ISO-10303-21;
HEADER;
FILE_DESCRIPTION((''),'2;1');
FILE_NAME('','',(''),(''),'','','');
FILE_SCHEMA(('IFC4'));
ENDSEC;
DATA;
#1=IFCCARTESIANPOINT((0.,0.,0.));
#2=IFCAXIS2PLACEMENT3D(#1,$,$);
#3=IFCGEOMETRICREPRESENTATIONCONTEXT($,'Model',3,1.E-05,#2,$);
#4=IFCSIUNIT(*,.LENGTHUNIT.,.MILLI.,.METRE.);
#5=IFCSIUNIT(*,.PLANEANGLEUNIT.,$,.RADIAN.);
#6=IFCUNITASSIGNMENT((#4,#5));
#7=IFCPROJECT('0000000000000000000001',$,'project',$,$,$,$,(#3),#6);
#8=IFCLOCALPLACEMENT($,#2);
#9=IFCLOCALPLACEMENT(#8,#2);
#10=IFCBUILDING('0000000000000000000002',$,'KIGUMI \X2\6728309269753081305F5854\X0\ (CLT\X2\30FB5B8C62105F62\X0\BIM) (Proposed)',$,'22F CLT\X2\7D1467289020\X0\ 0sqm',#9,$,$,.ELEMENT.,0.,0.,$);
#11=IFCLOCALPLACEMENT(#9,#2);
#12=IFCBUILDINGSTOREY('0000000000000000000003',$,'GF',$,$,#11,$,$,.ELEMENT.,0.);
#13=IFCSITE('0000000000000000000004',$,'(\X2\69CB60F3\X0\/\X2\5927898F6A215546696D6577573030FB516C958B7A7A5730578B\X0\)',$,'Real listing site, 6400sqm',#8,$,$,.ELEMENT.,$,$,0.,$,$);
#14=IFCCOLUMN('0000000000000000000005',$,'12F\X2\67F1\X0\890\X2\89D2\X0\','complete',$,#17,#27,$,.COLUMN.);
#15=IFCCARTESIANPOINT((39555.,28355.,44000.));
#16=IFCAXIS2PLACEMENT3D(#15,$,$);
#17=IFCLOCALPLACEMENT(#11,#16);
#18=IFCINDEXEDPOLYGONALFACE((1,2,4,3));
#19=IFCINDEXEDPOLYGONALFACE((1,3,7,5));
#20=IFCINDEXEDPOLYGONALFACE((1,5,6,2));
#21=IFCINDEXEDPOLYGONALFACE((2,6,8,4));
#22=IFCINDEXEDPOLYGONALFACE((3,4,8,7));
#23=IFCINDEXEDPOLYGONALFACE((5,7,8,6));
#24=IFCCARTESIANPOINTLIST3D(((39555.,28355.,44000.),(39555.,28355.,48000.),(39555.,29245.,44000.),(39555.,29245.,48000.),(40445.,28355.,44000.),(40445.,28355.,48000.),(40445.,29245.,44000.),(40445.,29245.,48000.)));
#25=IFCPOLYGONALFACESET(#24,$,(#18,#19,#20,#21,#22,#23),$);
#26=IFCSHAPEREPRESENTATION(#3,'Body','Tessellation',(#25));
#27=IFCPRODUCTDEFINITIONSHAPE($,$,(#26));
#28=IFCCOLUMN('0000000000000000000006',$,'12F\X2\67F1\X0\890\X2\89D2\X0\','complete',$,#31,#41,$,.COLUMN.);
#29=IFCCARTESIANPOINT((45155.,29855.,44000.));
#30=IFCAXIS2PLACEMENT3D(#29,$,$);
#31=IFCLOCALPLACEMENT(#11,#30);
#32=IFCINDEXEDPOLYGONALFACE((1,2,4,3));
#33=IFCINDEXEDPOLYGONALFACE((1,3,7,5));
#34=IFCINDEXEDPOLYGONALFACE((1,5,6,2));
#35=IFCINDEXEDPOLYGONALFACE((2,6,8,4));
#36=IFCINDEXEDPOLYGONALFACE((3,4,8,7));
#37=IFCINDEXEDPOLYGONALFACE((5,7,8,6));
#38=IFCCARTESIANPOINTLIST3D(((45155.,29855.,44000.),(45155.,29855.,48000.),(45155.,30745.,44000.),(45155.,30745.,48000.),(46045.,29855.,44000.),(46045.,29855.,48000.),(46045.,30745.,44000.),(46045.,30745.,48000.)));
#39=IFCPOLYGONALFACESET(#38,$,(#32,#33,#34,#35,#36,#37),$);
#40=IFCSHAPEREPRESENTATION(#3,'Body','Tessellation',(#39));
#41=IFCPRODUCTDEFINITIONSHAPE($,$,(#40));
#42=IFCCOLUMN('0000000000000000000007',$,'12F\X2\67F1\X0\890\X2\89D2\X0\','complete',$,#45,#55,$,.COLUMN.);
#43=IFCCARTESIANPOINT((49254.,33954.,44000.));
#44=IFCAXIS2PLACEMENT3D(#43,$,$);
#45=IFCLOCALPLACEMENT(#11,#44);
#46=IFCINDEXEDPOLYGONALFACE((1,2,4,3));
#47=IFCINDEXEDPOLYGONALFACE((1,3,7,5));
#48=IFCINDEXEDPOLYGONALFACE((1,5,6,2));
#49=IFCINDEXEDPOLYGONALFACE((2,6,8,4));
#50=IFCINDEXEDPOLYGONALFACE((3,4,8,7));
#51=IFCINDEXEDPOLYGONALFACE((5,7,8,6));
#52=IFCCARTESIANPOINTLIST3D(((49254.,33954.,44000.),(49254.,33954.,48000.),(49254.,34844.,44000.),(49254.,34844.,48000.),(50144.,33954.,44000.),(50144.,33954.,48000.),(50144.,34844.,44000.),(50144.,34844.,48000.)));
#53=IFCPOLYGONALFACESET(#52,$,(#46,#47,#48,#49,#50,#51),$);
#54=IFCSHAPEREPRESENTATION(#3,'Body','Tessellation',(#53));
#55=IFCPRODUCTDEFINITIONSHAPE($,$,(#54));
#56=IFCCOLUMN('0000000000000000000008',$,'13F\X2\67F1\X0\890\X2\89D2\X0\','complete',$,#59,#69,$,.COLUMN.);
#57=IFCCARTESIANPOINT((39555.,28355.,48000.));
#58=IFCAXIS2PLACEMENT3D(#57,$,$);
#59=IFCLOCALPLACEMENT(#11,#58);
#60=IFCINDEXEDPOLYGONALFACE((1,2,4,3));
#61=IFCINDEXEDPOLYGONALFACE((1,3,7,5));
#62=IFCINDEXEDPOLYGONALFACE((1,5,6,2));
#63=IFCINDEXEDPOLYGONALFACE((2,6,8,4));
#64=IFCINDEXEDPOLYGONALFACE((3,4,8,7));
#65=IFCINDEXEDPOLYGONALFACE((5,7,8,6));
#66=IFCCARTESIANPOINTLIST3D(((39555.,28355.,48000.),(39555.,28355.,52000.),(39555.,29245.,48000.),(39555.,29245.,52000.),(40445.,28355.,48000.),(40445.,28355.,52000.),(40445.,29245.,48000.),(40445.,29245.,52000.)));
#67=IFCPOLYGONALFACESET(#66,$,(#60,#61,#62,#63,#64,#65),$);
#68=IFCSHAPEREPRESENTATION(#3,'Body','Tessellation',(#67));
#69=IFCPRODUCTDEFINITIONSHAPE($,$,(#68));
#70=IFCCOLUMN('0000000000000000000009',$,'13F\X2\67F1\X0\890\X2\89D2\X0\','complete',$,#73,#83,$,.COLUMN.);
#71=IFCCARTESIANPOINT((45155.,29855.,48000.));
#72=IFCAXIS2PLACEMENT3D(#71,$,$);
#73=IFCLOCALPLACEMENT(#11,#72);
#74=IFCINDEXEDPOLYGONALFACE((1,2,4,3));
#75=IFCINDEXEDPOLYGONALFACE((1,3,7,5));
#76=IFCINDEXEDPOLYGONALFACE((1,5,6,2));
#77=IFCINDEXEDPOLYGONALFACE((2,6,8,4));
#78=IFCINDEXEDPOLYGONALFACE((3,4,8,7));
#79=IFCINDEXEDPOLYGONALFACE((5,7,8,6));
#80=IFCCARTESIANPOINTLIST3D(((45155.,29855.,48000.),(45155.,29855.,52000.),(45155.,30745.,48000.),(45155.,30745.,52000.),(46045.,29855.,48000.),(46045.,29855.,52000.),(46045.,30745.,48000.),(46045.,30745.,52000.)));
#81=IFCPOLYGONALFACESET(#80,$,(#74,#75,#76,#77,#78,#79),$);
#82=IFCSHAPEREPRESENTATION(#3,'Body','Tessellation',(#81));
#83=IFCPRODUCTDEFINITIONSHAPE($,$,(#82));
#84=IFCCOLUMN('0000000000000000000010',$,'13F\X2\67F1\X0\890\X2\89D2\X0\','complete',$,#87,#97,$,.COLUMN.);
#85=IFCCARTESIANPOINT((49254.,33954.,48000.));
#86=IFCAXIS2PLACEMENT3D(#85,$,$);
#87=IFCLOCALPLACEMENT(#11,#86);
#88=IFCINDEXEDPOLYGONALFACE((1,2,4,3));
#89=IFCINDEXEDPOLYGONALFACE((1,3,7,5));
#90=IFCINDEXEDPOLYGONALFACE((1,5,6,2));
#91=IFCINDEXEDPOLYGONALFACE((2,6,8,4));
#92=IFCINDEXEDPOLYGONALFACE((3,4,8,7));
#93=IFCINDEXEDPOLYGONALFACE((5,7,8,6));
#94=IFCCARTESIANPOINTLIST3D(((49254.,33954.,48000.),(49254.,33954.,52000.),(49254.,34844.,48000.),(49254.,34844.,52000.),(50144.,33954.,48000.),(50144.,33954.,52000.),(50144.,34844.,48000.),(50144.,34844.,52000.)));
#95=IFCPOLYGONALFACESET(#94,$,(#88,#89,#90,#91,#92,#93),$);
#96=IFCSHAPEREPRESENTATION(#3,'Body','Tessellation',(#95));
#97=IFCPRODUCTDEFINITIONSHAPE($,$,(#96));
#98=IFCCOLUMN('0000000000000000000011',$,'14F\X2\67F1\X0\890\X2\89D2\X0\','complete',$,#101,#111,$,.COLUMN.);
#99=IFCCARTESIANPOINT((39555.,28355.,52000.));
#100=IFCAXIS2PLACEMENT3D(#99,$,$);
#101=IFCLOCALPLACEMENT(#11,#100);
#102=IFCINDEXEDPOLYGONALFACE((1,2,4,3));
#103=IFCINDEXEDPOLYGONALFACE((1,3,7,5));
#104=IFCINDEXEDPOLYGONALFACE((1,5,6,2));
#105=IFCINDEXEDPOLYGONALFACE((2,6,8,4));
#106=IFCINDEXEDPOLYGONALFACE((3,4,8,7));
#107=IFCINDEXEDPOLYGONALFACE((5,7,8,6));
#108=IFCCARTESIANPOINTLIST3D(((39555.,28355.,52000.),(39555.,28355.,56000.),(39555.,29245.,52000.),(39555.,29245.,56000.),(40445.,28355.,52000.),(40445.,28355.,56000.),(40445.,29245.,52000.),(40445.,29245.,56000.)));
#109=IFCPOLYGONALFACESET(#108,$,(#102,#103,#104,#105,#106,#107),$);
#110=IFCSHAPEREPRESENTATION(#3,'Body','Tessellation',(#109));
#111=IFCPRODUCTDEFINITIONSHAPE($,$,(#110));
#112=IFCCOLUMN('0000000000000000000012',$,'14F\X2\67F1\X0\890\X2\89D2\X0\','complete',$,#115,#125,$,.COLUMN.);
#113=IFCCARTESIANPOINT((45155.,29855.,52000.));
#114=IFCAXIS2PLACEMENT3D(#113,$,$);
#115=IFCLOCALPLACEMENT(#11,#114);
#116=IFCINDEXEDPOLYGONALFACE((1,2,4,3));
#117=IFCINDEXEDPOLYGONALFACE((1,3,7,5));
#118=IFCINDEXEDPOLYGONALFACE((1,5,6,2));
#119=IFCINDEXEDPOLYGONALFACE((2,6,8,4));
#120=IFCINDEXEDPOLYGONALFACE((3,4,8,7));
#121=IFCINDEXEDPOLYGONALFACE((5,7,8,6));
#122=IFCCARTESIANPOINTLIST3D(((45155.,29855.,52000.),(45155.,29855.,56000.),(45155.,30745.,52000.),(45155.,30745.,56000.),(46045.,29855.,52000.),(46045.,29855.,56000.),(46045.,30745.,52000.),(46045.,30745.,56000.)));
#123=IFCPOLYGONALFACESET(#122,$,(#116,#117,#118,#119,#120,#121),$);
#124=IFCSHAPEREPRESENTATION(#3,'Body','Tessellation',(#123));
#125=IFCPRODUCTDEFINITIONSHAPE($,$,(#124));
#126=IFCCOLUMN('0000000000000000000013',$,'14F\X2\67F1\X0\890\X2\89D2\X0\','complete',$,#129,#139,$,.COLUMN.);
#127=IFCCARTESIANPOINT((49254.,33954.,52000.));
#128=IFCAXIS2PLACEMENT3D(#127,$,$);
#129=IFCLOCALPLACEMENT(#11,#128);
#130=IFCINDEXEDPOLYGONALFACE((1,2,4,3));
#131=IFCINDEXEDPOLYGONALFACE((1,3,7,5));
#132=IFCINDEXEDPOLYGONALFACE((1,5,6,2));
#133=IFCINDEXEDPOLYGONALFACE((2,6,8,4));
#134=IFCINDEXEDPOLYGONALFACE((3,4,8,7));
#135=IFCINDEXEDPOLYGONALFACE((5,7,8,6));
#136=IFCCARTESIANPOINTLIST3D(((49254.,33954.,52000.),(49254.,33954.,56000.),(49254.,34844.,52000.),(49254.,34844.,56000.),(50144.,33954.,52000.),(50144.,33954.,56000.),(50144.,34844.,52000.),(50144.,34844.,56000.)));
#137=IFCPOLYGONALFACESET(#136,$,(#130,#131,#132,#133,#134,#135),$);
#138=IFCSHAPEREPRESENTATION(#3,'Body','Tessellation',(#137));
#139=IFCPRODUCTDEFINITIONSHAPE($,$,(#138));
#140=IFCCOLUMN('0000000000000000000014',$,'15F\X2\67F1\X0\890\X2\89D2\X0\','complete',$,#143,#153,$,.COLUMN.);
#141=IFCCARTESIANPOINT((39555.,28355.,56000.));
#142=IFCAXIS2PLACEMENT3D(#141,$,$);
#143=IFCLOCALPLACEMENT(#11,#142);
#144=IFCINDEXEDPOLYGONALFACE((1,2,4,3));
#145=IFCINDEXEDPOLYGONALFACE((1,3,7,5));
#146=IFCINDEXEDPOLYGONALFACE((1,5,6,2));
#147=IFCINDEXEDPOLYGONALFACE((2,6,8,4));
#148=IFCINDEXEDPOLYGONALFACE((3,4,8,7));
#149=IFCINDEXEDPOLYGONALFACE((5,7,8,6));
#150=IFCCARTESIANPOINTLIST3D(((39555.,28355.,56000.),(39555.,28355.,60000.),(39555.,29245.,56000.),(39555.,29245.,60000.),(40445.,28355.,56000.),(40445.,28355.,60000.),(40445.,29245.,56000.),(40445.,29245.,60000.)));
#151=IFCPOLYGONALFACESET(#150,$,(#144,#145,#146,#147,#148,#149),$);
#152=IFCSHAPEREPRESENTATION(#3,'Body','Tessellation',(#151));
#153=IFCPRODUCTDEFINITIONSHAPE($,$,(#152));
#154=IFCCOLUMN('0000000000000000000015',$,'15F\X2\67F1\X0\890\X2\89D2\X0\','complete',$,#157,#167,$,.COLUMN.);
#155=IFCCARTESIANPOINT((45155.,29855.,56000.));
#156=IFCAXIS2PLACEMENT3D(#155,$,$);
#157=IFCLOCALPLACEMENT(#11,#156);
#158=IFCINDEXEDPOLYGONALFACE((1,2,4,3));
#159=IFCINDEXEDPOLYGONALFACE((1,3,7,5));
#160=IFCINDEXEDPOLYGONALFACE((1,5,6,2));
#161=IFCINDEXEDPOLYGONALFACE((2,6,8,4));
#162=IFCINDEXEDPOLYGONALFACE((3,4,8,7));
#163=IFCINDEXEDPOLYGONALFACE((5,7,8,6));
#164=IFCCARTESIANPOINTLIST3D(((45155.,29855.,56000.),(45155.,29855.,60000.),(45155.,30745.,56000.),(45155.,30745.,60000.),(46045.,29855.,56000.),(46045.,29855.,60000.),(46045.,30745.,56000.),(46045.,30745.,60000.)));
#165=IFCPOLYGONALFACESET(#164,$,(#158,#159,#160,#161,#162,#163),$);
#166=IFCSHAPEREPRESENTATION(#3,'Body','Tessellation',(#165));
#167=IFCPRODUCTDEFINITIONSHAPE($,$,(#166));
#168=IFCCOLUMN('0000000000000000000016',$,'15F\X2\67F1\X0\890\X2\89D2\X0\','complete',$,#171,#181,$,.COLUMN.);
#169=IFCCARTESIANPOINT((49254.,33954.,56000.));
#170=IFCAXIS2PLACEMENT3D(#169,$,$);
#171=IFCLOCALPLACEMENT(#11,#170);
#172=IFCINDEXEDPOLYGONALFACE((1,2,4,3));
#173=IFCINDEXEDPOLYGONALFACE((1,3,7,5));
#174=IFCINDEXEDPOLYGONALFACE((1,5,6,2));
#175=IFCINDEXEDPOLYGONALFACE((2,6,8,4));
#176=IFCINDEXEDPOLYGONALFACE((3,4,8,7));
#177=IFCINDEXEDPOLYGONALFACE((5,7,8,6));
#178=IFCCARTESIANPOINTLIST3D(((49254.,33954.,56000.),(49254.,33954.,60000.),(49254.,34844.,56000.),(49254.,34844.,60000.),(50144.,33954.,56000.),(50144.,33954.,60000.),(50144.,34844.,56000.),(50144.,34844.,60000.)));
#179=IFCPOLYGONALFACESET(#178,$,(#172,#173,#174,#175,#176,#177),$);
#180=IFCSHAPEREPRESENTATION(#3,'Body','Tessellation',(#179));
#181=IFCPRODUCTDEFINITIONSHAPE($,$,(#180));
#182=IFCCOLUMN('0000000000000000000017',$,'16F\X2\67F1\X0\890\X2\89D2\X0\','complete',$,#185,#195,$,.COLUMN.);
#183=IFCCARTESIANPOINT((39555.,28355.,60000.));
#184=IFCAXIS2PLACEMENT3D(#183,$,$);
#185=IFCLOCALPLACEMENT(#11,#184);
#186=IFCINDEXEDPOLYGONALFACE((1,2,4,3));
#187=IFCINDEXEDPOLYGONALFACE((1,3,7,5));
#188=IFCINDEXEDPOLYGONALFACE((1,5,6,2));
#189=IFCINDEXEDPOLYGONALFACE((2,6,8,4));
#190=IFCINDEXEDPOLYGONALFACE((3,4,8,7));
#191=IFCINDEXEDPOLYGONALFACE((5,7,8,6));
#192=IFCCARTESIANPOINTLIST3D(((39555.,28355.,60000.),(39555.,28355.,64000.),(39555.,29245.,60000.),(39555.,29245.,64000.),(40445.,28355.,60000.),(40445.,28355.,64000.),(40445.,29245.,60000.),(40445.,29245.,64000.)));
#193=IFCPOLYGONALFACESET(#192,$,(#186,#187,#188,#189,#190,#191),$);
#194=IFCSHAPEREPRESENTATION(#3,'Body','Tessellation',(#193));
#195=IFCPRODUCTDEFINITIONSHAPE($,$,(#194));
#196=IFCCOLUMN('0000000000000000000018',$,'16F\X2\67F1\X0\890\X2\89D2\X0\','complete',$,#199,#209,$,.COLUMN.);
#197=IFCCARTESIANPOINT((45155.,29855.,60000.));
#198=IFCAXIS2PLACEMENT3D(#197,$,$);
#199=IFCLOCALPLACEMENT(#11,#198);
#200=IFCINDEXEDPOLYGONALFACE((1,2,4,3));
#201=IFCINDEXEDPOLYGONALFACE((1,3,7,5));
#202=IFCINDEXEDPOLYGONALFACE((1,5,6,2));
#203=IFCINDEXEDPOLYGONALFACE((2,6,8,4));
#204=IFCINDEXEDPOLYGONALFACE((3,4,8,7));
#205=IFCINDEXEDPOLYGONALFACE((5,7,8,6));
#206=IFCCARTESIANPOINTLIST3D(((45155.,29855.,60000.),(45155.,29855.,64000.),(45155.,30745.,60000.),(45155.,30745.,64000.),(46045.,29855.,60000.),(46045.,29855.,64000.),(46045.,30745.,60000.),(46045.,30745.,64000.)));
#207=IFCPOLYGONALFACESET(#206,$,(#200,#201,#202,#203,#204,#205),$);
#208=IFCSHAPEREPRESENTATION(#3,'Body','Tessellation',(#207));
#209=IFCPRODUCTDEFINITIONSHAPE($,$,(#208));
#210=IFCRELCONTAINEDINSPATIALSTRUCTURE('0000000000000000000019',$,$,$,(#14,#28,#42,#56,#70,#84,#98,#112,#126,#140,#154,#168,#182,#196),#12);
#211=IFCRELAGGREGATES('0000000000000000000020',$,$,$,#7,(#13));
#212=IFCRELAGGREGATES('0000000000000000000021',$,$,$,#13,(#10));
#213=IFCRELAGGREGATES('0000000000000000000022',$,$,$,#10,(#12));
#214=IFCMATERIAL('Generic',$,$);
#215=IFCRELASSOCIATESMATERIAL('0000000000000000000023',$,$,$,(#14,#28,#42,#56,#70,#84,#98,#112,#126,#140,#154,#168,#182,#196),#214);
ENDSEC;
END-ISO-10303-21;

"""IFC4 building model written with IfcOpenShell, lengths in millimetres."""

from ifc_helpers import new_model, si_unit, frame, frame_2d, origin, place, context, project, spatial, rectangle, extrude, material, element, save


model = new_model("IFC4")

# Units and contexts
model_context = context("Model", 3, precision=1e-05, world=origin())
ifc_project = project(units=[si_unit("LENGTHUNIT", "METRE", prefix="MILLI"), si_unit("PLANEANGLEUNIT", "RADIAN")], contexts=[model_context])

# Site, building, storey
site_placement = place(None, origin())
site = spatial("IfcSite", under=ifc_project, at=site_placement, Name="(構想/大規模商業敷地・公開空地型)", ObjectType="Real listing site, 6400sqm", CompositionType="ELEMENT", RefElevation=0.0)
building_placement = place(site_placement, origin())
building = spatial("IfcBuilding", under=site, at=building_placement, Name="KIGUMI 木を極めた塔 (CLT・完成形BIM) (Proposed)", ObjectType="22F CLT純木造 0sqm", CompositionType="ELEMENT", ElevationOfRefHeight=0.0, ElevationOfTerrain=0.0)
storey_placement = place(building_placement, origin())
storey = spatial("IfcBuildingStorey", under=building, at=storey_placement, Name="GF", CompositionType="ELEMENT", Elevation=0.0)

# Columns
ifc_material = material(Name="Generic")
column_1_placement = place(storey_placement, frame((39555.0, 28355.0, 44000.0)))
element("IfcColumn", 1, at=column_1_placement, inside=storey, material=ifc_material, Name="12F柱890角", Description="complete", PredefinedType="COLUMN", context=model_context, shape_type="SweptSolid", body=[
    extrude(rectangle(XDim=890.0, YDim=890.0, at=frame_2d((445.0, 445.0))), frame((39555.0, 28355.0, 44000.0)), (0.0, 0.0, 1.0), 4000.0),
])
column_2_placement = place(storey_placement, frame((45155.0, 29855.0, 44000.0)))
element("IfcColumn", 2, at=column_2_placement, inside=storey, material=ifc_material, Name="12F柱890角", Description="complete", PredefinedType="COLUMN", context=model_context, shape_type="SweptSolid", body=[
    extrude(rectangle(XDim=890.0, YDim=890.0, at=frame_2d((445.0, 445.0))), frame((45155.0, 29855.0, 44000.0)), (0.0, 0.0, 1.0), 4000.0),
])
column_3_placement = place(storey_placement, frame((49254.0, 33954.0, 44000.0)))
element("IfcColumn", 3, at=column_3_placement, inside=storey, material=ifc_material, Name="12F柱890角", Description="complete", PredefinedType="COLUMN", context=model_context, shape_type="SweptSolid", body=[
    extrude(rectangle(XDim=890.0, YDim=890.0, at=frame_2d((445.0, 445.0))), frame((49254.0, 33954.0, 44000.0)), (0.0, 0.0, 1.0), 4000.0),
])
column_4_placement = place(storey_placement, frame((39555.0, 28355.0, 48000.0)))
element("IfcColumn", 4, at=column_4_placement, inside=storey, material=ifc_material, Name="13F柱890角", Description="complete", PredefinedType="COLUMN", context=model_context, shape_type="SweptSolid", body=[
    extrude(rectangle(XDim=890.0, YDim=890.0, at=frame_2d((445.0, 445.0))), frame((39555.0, 28355.0, 48000.0)), (0.0, 0.0, 1.0), 4000.0),
])
column_5_placement = place(storey_placement, frame((45155.0, 29855.0, 48000.0)))
element("IfcColumn", 5, at=column_5_placement, inside=storey, material=ifc_material, Name="13F柱890角", Description="complete", PredefinedType="COLUMN", context=model_context, shape_type="SweptSolid", body=[
    extrude(rectangle(XDim=890.0, YDim=890.0, at=frame_2d((445.0, 445.0))), frame((45155.0, 29855.0, 48000.0)), (0.0, 0.0, 1.0), 4000.0),
])
column_6_placement = place(storey_placement, frame((49254.0, 33954.0, 48000.0)))
element("IfcColumn", 6, at=column_6_placement, inside=storey, material=ifc_material, Name="13F柱890角", Description="complete", PredefinedType="COLUMN", context=model_context, shape_type="SweptSolid", body=[
    extrude(rectangle(XDim=890.0, YDim=890.0, at=frame_2d((445.0, 445.0))), frame((49254.0, 33954.0, 48000.0)), (0.0, 0.0, 1.0), 4000.0),
])
column_7_placement = place(storey_placement, frame((39555.0, 28355.0, 52000.0)))
element("IfcColumn", 7, at=column_7_placement, inside=storey, material=ifc_material, Name="14F柱890角", Description="complete", PredefinedType="COLUMN", context=model_context, shape_type="SweptSolid", body=[
    extrude(rectangle(XDim=890.0, YDim=890.0, at=frame_2d((445.0, 445.0))), frame((39555.0, 28355.0, 52000.0)), (0.0, 0.0, 1.0), 4000.0),
])
column_8_placement = place(storey_placement, frame((45155.0, 29855.0, 52000.0)))
element("IfcColumn", 8, at=column_8_placement, inside=storey, material=ifc_material, Name="14F柱890角", Description="complete", PredefinedType="COLUMN", context=model_context, shape_type="SweptSolid", body=[
    extrude(rectangle(XDim=890.0, YDim=890.0, at=frame_2d((445.0, 445.0))), frame((45155.0, 29855.0, 52000.0)), (0.0, 0.0, 1.0), 4000.0),
])
column_9_placement = place(storey_placement, frame((49254.0, 33954.0, 52000.0)))
element("IfcColumn", 9, at=column_9_placement, inside=storey, material=ifc_material, Name="14F柱890角", Description="complete", PredefinedType="COLUMN", context=model_context, shape_type="SweptSolid", body=[
    extrude(rectangle(XDim=890.0, YDim=890.0, at=frame_2d((445.0, 445.0))), frame((49254.0, 33954.0, 52000.0)), (0.0, 0.0, 1.0), 4000.0),
])
column_10_placement = place(storey_placement, frame((39555.0, 28355.0, 56000.0)))
element("IfcColumn", 10, at=column_10_placement, inside=storey, material=ifc_material, Name="15F柱890角", Description="complete", PredefinedType="COLUMN", context=model_context, shape_type="SweptSolid", body=[
    extrude(rectangle(XDim=890.0, YDim=890.0, at=frame_2d((445.0, 445.0))), frame((39555.0, 28355.0, 56000.0)), (0.0, 0.0, 1.0), 4000.0),
])
column_11_placement = place(storey_placement, frame((45155.0, 29855.0, 56000.0)))
element("IfcColumn", 11, at=column_11_placement, inside=storey, material=ifc_material, Name="15F柱890角", Description="complete", PredefinedType="COLUMN", context=model_context, shape_type="SweptSolid", body=[
    extrude(rectangle(XDim=890.0, YDim=890.0, at=frame_2d((445.0, 445.0))), frame((45155.0, 29855.0, 56000.0)), (0.0, 0.0, 1.0), 4000.0),
])
column_12_placement = place(storey_placement, frame((49254.0, 33954.0, 56000.0)))
element("IfcColumn", 12, at=column_12_placement, inside=storey, material=ifc_material, Name="15F柱890角", Description="complete", PredefinedType="COLUMN", context=model_context, shape_type="SweptSolid", body=[
    extrude(rectangle(XDim=890.0, YDim=890.0, at=frame_2d((445.0, 445.0))), frame((49254.0, 33954.0, 56000.0)), (0.0, 0.0, 1.0), 4000.0),
])
column_13_placement = place(storey_placement, frame((39555.0, 28355.0, 60000.0)))
element("IfcColumn", 13, at=column_13_placement, inside=storey, material=ifc_material, Name="16F柱890角", Description="complete", PredefinedType="COLUMN", context=model_context, shape_type="SweptSolid", body=[
    extrude(rectangle(XDim=890.0, YDim=890.0, at=frame_2d((445.0, 445.0))), frame((39555.0, 28355.0, 60000.0)), (0.0, 0.0, 1.0), 4000.0),
])
column_14_placement = place(storey_placement, frame((45155.0, 29855.0, 60000.0)))
element("IfcColumn", 14, at=column_14_placement, inside=storey, material=ifc_material, Name="16F柱890角", Description="complete", PredefinedType="COLUMN", context=model_context, shape_type="SweptSolid", body=[
    extrude(rectangle(XDim=890.0, YDim=890.0, at=frame_2d((445.0, 445.0))), frame((45155.0, 29855.0, 60000.0)), (0.0, 0.0, 1.0), 4000.0),
])

save(model, "model.ifc")
